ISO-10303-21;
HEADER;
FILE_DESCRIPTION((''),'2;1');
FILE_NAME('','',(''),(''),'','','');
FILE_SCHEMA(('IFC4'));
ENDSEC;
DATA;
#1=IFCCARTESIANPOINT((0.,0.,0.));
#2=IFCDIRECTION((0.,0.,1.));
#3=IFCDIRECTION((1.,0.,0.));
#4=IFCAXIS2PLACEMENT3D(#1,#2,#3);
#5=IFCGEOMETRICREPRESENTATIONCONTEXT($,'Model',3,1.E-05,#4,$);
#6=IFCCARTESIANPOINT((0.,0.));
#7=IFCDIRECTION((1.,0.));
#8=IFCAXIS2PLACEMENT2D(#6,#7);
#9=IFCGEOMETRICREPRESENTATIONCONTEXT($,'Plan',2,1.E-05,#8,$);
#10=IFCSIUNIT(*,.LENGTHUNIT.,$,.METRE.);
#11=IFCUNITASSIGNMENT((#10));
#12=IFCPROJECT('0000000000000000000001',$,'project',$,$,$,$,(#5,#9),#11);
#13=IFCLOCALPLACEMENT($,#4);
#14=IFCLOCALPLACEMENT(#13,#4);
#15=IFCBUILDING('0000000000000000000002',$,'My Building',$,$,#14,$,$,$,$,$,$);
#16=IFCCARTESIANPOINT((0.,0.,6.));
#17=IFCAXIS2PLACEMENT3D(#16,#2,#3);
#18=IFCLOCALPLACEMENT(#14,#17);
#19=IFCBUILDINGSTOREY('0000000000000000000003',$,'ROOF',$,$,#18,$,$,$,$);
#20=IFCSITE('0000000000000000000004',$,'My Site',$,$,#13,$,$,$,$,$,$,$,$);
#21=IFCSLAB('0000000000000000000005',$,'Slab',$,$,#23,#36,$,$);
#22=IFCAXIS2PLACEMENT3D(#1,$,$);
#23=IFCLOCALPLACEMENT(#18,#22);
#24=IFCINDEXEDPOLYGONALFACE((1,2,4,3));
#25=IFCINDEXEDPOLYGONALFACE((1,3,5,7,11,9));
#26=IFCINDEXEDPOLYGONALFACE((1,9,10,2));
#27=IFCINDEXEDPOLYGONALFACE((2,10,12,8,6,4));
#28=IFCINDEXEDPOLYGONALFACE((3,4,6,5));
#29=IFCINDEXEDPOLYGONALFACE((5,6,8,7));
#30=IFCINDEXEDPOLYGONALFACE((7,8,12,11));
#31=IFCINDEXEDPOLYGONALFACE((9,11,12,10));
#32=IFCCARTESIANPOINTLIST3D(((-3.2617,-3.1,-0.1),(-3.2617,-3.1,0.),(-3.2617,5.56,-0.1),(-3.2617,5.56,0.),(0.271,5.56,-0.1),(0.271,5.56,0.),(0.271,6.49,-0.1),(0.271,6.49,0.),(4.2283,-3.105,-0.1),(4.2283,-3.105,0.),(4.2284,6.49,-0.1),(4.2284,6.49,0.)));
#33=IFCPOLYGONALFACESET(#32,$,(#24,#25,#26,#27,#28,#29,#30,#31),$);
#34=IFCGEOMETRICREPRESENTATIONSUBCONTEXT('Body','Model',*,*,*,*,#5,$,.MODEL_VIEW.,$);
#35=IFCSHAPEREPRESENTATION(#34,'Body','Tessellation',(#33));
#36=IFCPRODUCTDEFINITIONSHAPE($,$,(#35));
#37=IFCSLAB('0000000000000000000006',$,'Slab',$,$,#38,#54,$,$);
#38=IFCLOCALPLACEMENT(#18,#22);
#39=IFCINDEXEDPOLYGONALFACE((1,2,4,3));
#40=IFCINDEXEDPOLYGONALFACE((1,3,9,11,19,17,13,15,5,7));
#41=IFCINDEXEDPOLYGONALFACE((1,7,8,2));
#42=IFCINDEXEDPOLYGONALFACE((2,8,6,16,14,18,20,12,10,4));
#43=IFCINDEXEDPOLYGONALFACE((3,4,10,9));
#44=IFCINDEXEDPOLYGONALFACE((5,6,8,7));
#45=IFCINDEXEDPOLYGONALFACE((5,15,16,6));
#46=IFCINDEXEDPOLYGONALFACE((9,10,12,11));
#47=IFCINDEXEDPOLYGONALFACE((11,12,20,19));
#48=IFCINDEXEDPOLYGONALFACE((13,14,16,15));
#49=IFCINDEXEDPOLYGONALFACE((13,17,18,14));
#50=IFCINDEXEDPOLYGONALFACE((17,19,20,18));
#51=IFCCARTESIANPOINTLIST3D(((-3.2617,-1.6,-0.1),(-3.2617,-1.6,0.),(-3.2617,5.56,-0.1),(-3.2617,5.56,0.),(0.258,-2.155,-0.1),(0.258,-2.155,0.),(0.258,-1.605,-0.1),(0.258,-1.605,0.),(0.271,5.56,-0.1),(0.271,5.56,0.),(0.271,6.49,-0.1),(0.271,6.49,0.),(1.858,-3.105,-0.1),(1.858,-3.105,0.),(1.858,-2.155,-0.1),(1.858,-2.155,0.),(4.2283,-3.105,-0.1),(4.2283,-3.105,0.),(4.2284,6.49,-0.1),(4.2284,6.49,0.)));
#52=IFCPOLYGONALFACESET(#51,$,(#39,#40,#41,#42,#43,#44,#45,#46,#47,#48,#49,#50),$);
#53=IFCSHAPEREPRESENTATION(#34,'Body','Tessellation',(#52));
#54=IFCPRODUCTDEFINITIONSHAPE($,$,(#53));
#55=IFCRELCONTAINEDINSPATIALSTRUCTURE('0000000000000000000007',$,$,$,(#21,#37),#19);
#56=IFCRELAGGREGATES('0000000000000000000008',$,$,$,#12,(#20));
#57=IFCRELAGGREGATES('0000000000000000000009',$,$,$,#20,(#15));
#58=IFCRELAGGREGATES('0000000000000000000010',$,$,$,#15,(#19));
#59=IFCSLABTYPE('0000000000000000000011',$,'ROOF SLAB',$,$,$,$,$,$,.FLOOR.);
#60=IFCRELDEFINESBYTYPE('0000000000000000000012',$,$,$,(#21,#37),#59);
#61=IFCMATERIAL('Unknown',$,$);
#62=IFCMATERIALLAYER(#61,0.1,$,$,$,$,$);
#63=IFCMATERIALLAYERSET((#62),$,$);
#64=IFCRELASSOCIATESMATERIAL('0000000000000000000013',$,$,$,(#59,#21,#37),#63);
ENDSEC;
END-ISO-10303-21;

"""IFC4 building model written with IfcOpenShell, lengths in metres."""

from ifc_helpers import new_model, si_unit, frame, origin_with_axes, origin_2d_with_axis, place, context, subcontext, project, spatial, indexed_curve, outline, extrude, material, layer, layer_set, layer_usage, type_object, element, save


model = new_model("IFC4")

# Units and contexts
model_context = context("Model", 3, precision=1e-05, world=origin_with_axes())
plan_context = context("Plan", 2, precision=1e-05, world=origin_2d_with_axis())
body_context = subcontext(model_context, "Body", "Model", "MODEL_VIEW")
ifc_project = project(units=[si_unit("LENGTHUNIT", "METRE")], contexts=[model_context, plan_context])

# Site, building, storey
site_placement = place(None, origin_with_axes())
site = spatial("IfcSite", under=ifc_project, at=site_placement, Name="My Site")
building_placement = place(site_placement, origin_with_axes())
building = spatial("IfcBuilding", under=site, at=building_placement, Name="My Building")
storey_placement = place(building_placement, frame((0.0, 0.0, 6.0), z_axis=(0.0, 0.0, 1.0), x_axis=(1.0, 0.0, 0.0)))
storey = spatial("IfcBuildingStorey", under=building, at=storey_placement, Name="ROOF")

# Slabs
ifc_material = material(Name="Unknown")
ifc_layer = layer(ifc_material, 0.1)
ifc_layer_set = layer_set([ifc_layer])
ifc_layer_usage_1 = layer_usage(ifc_layer_set, "AXIS3", "POSITIVE", -0.1)
slab_type = type_object("IfcSlabType", Name="ROOF SLAB", PredefinedType="FLOOR", material=ifc_layer_set)
slab_1_placement = place(storey_placement, frame((4.2284, 6.49, 0.0), z_axis=(0.0, 0.0, 1.0), x_axis=(1.0, 0.0, 0.0)))
element("IfcSlab", 1, at=slab_1_placement, inside=storey, type_object=slab_type, material=ifc_layer_usage_1, Name="Slab", context=body_context, shape_type="SweptSolid", body=[
    extrude(outline(indexed_curve([(0.0, 0.0), (-3.9573, 0.0), (-3.9573, -0.93), (-7.49, -0.93), (-7.49, -9.59), (0.0, -9.5949), (0.0, 0.0)])), frame((0.0, 0.0, -0.1), z_axis=(0.0, 0.0, 1.0), x_axis=(1.0, 0.0, 0.0)), (0.0, 0.0, 1.0), 0.1),
])
ifc_layer_usage_2 = layer_usage(ifc_layer_set, "AXIS3", "POSITIVE", -0.1)
slab_2_placement = place(storey_placement, frame((4.2284, 6.49, 0.0), z_axis=(0.0, 0.0, 1.0), x_axis=(1.0, 0.0, 0.0)))
element("IfcSlab", 2, at=slab_2_placement, inside=storey, type_object=slab_type, material=ifc_layer_usage_2, Name="Slab", context=body_context, shape_type="SweptSolid", body=[
    extrude(outline(indexed_curve([(0.0, 0.0), (-3.9573, 0.0), (-3.9573, -0.93), (-7.49, -0.93), (-7.49, -8.09), (-3.9703, -8.0949), (-3.9703, -8.6449), (-2.3703, -8.6449), (-2.3703, -9.5949), (0.0, -9.5949), (0.0, 0.0)])), frame((0.0, 0.0, -0.1), z_axis=(0.0, 0.0, 1.0), x_axis=(1.0, 0.0, 0.0)), (0.0, 0.0, 1.0), 0.1),
])

save(model, "model.ifc")
